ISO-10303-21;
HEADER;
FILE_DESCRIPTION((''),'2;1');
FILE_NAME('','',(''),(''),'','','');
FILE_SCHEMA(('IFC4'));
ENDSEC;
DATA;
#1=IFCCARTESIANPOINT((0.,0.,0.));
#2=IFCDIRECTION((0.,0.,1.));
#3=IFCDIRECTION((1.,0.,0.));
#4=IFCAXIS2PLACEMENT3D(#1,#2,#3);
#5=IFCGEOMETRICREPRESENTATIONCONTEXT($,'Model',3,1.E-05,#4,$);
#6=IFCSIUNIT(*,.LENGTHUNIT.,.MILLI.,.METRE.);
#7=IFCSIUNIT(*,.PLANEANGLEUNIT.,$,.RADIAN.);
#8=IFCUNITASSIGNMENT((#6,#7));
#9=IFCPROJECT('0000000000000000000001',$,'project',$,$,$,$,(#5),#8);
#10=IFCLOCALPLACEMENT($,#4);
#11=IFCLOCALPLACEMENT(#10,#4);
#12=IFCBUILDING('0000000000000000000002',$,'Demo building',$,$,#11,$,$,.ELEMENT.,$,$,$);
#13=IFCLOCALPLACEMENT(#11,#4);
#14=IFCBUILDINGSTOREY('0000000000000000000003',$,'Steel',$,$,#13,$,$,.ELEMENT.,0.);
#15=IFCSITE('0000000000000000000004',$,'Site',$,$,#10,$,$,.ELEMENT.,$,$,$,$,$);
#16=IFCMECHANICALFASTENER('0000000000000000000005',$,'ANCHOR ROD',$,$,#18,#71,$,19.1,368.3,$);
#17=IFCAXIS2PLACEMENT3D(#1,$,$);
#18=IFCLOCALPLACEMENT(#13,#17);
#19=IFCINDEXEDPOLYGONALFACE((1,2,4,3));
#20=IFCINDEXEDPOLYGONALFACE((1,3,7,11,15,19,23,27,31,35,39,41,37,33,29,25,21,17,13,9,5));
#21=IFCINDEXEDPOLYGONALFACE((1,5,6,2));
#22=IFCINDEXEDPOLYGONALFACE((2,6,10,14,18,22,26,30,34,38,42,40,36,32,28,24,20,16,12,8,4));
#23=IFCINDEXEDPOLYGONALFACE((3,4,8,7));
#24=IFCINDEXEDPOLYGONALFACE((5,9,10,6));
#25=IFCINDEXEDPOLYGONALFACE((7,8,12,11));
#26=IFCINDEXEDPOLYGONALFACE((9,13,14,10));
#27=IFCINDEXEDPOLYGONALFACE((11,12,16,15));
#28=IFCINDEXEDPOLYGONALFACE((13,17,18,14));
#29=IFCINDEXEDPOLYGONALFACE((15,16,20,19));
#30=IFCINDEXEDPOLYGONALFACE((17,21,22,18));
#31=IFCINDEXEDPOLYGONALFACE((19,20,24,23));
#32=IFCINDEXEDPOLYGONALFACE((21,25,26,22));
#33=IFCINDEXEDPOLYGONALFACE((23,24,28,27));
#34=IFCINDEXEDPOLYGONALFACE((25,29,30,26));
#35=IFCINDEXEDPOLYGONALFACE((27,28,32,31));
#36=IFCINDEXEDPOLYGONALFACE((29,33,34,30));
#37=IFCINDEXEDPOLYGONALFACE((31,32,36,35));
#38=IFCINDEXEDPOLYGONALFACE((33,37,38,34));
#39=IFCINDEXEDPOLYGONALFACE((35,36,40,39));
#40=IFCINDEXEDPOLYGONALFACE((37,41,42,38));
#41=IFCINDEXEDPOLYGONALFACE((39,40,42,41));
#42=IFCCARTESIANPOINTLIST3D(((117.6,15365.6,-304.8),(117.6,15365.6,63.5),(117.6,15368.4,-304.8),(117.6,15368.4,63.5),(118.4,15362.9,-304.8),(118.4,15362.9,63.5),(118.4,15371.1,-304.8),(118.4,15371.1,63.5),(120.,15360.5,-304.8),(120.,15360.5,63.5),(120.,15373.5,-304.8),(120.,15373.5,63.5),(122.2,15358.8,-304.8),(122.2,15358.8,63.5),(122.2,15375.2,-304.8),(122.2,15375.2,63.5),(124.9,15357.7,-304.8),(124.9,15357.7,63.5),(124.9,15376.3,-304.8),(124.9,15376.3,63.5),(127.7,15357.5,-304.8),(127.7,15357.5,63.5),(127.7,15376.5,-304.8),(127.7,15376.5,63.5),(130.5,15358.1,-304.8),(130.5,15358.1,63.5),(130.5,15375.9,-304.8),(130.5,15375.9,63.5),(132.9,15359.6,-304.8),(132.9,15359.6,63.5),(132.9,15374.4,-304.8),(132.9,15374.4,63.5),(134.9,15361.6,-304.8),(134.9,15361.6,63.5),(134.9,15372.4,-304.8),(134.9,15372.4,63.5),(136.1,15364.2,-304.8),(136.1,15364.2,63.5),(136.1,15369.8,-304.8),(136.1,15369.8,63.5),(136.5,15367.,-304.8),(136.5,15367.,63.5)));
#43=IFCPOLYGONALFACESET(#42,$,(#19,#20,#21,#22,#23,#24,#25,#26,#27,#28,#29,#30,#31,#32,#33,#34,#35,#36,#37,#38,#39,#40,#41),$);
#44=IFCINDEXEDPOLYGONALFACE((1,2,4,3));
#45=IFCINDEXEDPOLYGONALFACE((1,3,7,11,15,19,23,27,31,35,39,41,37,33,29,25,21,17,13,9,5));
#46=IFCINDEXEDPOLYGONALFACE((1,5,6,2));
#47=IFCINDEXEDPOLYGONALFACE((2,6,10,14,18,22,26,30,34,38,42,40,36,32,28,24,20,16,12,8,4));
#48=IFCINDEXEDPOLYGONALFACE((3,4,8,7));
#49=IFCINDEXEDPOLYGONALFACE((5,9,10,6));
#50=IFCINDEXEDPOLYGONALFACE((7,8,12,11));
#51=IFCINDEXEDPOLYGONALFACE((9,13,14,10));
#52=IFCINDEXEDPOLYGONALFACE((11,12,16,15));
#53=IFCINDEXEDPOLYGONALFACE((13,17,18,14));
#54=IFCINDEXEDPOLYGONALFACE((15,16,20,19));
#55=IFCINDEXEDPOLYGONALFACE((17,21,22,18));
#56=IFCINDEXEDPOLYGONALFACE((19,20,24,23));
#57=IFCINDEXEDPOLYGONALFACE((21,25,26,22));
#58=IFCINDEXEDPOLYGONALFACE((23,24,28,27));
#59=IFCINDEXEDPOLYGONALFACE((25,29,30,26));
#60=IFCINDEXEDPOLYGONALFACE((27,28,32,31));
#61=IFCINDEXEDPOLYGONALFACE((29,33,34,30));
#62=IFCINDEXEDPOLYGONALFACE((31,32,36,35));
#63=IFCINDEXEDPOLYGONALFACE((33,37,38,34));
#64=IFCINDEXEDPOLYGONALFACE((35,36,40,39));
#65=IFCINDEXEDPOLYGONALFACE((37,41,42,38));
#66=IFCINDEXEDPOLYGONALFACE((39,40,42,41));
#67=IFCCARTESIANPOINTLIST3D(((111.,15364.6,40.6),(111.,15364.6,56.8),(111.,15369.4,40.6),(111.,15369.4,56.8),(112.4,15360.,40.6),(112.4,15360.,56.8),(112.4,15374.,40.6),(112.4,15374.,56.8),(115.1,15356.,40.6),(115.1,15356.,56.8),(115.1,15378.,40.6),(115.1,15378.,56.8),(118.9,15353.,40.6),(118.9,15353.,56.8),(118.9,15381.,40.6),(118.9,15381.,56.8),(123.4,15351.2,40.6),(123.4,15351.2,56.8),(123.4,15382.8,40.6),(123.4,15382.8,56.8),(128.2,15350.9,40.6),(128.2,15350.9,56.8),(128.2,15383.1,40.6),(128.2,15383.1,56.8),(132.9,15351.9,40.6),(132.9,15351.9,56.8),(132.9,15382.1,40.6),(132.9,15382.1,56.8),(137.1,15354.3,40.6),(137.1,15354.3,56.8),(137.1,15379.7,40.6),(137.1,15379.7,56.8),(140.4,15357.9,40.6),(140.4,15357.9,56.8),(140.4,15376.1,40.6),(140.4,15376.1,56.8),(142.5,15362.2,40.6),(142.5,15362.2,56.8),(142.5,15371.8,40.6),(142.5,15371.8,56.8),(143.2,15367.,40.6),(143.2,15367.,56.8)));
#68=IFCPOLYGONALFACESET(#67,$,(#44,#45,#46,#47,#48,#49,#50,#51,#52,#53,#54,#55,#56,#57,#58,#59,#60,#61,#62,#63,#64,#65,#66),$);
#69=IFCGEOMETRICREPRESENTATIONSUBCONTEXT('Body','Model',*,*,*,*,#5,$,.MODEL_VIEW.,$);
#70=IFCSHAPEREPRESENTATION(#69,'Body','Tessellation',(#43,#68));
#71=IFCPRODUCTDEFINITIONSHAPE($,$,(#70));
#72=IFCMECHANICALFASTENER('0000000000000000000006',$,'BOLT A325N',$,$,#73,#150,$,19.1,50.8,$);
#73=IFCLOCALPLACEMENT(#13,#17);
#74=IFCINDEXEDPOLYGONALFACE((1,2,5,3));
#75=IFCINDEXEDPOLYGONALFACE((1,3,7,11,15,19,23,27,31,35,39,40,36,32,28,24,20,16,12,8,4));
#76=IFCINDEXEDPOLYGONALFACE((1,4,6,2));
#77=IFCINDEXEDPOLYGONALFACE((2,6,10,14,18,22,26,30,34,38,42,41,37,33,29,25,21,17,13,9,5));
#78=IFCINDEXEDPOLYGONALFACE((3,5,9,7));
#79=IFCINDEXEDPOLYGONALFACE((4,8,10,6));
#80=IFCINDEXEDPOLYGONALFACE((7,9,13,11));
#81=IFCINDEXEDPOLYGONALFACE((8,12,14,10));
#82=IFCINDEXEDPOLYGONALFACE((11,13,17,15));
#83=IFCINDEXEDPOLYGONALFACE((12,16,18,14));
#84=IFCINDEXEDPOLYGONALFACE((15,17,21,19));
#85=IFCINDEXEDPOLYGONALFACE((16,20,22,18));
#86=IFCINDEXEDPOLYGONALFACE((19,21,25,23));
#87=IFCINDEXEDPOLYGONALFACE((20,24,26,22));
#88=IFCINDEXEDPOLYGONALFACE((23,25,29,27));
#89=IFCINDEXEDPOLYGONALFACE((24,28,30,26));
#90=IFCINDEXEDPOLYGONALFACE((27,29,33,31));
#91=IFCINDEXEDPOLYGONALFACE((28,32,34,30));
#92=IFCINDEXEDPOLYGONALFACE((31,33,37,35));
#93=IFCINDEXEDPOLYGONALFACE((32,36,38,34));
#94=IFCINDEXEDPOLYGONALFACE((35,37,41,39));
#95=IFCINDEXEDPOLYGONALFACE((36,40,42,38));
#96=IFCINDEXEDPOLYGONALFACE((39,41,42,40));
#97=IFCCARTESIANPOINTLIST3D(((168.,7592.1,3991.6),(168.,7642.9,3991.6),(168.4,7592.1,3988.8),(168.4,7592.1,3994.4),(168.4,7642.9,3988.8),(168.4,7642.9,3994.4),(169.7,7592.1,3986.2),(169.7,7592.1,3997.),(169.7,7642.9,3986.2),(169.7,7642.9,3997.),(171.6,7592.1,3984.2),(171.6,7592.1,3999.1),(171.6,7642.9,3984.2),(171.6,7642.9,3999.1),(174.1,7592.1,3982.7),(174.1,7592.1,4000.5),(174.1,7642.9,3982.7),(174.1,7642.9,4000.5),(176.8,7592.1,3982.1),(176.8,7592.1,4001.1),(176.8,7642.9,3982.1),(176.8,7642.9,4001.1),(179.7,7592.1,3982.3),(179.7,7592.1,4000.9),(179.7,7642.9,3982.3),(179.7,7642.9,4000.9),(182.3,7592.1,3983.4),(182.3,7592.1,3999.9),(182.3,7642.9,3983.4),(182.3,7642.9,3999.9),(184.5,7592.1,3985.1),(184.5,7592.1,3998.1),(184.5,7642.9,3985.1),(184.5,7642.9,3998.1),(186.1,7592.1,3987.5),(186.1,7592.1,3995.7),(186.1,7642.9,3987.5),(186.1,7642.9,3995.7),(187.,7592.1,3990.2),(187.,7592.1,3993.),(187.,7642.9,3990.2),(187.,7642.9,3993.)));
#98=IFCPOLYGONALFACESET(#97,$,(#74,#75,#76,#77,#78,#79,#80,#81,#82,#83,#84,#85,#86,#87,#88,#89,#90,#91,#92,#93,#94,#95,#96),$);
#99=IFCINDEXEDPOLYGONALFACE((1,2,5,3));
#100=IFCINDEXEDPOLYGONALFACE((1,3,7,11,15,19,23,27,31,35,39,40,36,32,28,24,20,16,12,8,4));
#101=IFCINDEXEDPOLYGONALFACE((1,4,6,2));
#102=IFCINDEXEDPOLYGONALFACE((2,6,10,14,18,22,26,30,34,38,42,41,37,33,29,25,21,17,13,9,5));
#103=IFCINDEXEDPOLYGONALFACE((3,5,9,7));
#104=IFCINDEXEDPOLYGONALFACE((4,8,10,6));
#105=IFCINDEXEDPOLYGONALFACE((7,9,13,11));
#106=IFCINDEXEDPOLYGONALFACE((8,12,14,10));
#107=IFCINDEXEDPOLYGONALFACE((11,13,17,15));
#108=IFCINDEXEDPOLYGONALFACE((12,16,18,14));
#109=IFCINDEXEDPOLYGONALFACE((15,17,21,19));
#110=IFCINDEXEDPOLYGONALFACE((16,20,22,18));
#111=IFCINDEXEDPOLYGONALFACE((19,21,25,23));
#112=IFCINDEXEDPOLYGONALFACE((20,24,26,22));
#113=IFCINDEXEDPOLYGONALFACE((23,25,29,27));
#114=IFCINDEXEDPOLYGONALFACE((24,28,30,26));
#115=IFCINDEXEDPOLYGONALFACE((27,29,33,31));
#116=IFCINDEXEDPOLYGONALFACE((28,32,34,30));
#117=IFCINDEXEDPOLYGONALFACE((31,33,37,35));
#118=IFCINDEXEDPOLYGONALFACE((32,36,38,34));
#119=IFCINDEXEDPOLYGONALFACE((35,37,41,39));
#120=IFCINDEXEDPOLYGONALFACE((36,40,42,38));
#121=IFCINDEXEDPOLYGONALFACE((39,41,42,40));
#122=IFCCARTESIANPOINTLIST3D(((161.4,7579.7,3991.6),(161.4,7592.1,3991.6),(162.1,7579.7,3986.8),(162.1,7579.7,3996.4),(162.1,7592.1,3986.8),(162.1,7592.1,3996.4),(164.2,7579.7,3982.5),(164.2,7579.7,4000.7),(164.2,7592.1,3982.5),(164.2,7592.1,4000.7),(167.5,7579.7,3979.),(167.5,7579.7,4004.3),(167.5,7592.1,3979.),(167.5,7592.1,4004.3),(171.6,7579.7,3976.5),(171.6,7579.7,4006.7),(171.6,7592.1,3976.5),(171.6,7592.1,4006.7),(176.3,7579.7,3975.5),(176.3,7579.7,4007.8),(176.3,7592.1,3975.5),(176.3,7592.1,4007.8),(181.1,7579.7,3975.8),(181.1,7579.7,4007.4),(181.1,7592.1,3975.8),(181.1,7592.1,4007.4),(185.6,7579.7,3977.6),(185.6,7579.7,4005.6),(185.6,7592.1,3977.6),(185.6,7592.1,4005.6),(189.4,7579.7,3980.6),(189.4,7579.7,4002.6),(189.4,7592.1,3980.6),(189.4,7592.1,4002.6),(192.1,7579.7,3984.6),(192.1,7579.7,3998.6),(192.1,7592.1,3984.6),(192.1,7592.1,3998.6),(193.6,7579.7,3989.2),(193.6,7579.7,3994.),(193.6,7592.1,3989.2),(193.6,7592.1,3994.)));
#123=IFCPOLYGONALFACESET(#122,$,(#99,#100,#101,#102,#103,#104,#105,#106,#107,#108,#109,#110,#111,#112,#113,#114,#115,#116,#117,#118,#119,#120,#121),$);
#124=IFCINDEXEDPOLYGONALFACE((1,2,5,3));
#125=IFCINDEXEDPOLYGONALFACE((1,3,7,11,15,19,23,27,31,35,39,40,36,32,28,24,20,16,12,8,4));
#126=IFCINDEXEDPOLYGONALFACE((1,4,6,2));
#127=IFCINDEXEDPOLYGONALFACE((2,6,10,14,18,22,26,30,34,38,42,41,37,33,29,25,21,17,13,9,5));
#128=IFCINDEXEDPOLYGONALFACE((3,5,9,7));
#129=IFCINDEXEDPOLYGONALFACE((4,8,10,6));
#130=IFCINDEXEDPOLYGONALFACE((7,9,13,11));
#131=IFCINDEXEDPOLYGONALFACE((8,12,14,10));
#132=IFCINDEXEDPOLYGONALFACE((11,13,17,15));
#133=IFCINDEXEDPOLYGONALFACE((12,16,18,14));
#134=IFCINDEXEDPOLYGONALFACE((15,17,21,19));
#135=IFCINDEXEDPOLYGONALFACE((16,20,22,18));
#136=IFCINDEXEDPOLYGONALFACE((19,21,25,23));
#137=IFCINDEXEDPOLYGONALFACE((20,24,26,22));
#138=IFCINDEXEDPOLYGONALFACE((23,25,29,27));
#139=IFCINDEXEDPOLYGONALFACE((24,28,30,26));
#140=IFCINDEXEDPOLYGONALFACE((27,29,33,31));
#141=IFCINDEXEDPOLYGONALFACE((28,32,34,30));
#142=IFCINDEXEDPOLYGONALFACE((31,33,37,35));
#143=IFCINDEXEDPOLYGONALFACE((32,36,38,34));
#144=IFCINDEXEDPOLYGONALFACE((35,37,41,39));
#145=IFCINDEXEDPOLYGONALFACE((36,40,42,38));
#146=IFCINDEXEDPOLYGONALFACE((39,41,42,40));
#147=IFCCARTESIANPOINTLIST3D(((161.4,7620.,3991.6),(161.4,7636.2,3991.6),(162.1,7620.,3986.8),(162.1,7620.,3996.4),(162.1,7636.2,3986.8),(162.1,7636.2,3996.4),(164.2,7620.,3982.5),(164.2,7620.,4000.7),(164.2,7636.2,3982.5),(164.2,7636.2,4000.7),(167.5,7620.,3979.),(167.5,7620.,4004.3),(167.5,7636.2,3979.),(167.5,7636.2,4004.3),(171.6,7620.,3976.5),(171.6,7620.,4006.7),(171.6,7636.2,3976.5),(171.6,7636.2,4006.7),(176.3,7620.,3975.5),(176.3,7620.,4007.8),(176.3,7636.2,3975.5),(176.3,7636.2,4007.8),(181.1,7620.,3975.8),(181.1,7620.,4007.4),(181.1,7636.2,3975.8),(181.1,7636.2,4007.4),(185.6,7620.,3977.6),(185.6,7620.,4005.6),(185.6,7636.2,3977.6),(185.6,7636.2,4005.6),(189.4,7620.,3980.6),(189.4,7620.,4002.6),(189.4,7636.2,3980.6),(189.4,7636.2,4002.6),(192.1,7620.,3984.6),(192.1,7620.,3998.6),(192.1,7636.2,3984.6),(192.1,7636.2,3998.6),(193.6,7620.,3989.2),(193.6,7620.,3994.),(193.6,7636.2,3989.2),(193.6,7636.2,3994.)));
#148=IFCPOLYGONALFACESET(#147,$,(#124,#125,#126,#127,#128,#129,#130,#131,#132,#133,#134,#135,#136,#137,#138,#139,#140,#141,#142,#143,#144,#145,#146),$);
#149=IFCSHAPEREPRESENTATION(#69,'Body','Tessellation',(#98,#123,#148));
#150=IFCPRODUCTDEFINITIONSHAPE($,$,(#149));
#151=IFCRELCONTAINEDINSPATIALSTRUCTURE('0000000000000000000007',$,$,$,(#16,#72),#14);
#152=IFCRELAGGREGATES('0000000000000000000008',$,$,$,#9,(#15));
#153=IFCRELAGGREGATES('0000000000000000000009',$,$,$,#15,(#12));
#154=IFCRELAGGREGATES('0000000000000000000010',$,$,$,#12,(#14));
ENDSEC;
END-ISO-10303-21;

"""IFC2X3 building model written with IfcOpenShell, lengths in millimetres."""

from ifc_helpers import new_model, si_unit, frame, origin, origin_with_axes, origin_2d, place, context, subcontext, project, spatial, circle, extrude, element, save


model = new_model("IFC2X3")

# Units and contexts
model_context = context("Model", 3, precision=1e-05, world=origin_with_axes())
body_context = subcontext(model_context, "Body", "Model", "MODEL_VIEW")
ifc_project = project(units=[si_unit("LENGTHUNIT", "METRE", prefix="MILLI"), si_unit("PLANEANGLEUNIT", "RADIAN")], contexts=[model_context])

# Site, building, storey
site_placement = place(None, origin_with_axes())
site = spatial("IfcSite", under=ifc_project, at=site_placement, Name="Site", CompositionType="ELEMENT")
building_placement = place(site_placement, origin_with_axes())
building = spatial("IfcBuilding", under=site, at=building_placement, Name="Demo building", CompositionType="ELEMENT")
placement = place(building_placement, origin_with_axes())
storey = spatial("IfcBuildingStorey", under=building, at=placement, Name="Steel", CompositionType="ELEMENT", Elevation=0.0)

# Mechanical fasteners
for number, where, z_axis, x_axis, name in (
    (1, (127.0, 15367.0, -304.8), (0.0, 0.0, 1.0), (1.0, 0.0, 0.0), "ANCHOR ROD"),
):
    element("IfcMechanicalFastener", number, at=place(placement, frame(where, z_axis=z_axis, x_axis=x_axis)), inside=storey, Name=name, NominalDiameter=19.1, NominalLength=368.3, context=body_context, shape_type="SweptSolid", body=[
        extrude(circle(Radius=9.5, at=origin_2d()), origin(), (0.0, 0.0, 1.0), 368.3),
        extrude(circle(Radius=16.2, at=origin_2d()), frame((0.0, 0.0, 345.4)), (0.0, 0.0, 1.0), 16.2),
    ])
for number, where, z_axis, x_axis, name in (
    (2, (177.5, 7592.1, 3991.6), (0.0, 1.0, 0.0), (-1.0, 0.0, 0.0), "BOLT A325N"),
):
    element("IfcMechanicalFastener", number, at=place(placement, frame(where, z_axis=z_axis, x_axis=x_axis)), inside=storey, Name=name, NominalDiameter=19.1, NominalLength=50.8, context=body_context, shape_type="SweptSolid", body=[
        extrude(circle(Radius=9.5, at=origin_2d()), origin(), (0.0, 0.0, 1.0), 50.8),
        extrude(circle(Radius=16.2, at=origin_2d()), frame((0.0, 0.0, -12.4)), (0.0, 0.0, 1.0), 12.4),
        extrude(circle(Radius=16.2, at=origin_2d()), frame((0.0, 0.0, 27.9)), (0.0, 0.0, 1.0), 16.2),
    ])

save(model, "model.ifc")
